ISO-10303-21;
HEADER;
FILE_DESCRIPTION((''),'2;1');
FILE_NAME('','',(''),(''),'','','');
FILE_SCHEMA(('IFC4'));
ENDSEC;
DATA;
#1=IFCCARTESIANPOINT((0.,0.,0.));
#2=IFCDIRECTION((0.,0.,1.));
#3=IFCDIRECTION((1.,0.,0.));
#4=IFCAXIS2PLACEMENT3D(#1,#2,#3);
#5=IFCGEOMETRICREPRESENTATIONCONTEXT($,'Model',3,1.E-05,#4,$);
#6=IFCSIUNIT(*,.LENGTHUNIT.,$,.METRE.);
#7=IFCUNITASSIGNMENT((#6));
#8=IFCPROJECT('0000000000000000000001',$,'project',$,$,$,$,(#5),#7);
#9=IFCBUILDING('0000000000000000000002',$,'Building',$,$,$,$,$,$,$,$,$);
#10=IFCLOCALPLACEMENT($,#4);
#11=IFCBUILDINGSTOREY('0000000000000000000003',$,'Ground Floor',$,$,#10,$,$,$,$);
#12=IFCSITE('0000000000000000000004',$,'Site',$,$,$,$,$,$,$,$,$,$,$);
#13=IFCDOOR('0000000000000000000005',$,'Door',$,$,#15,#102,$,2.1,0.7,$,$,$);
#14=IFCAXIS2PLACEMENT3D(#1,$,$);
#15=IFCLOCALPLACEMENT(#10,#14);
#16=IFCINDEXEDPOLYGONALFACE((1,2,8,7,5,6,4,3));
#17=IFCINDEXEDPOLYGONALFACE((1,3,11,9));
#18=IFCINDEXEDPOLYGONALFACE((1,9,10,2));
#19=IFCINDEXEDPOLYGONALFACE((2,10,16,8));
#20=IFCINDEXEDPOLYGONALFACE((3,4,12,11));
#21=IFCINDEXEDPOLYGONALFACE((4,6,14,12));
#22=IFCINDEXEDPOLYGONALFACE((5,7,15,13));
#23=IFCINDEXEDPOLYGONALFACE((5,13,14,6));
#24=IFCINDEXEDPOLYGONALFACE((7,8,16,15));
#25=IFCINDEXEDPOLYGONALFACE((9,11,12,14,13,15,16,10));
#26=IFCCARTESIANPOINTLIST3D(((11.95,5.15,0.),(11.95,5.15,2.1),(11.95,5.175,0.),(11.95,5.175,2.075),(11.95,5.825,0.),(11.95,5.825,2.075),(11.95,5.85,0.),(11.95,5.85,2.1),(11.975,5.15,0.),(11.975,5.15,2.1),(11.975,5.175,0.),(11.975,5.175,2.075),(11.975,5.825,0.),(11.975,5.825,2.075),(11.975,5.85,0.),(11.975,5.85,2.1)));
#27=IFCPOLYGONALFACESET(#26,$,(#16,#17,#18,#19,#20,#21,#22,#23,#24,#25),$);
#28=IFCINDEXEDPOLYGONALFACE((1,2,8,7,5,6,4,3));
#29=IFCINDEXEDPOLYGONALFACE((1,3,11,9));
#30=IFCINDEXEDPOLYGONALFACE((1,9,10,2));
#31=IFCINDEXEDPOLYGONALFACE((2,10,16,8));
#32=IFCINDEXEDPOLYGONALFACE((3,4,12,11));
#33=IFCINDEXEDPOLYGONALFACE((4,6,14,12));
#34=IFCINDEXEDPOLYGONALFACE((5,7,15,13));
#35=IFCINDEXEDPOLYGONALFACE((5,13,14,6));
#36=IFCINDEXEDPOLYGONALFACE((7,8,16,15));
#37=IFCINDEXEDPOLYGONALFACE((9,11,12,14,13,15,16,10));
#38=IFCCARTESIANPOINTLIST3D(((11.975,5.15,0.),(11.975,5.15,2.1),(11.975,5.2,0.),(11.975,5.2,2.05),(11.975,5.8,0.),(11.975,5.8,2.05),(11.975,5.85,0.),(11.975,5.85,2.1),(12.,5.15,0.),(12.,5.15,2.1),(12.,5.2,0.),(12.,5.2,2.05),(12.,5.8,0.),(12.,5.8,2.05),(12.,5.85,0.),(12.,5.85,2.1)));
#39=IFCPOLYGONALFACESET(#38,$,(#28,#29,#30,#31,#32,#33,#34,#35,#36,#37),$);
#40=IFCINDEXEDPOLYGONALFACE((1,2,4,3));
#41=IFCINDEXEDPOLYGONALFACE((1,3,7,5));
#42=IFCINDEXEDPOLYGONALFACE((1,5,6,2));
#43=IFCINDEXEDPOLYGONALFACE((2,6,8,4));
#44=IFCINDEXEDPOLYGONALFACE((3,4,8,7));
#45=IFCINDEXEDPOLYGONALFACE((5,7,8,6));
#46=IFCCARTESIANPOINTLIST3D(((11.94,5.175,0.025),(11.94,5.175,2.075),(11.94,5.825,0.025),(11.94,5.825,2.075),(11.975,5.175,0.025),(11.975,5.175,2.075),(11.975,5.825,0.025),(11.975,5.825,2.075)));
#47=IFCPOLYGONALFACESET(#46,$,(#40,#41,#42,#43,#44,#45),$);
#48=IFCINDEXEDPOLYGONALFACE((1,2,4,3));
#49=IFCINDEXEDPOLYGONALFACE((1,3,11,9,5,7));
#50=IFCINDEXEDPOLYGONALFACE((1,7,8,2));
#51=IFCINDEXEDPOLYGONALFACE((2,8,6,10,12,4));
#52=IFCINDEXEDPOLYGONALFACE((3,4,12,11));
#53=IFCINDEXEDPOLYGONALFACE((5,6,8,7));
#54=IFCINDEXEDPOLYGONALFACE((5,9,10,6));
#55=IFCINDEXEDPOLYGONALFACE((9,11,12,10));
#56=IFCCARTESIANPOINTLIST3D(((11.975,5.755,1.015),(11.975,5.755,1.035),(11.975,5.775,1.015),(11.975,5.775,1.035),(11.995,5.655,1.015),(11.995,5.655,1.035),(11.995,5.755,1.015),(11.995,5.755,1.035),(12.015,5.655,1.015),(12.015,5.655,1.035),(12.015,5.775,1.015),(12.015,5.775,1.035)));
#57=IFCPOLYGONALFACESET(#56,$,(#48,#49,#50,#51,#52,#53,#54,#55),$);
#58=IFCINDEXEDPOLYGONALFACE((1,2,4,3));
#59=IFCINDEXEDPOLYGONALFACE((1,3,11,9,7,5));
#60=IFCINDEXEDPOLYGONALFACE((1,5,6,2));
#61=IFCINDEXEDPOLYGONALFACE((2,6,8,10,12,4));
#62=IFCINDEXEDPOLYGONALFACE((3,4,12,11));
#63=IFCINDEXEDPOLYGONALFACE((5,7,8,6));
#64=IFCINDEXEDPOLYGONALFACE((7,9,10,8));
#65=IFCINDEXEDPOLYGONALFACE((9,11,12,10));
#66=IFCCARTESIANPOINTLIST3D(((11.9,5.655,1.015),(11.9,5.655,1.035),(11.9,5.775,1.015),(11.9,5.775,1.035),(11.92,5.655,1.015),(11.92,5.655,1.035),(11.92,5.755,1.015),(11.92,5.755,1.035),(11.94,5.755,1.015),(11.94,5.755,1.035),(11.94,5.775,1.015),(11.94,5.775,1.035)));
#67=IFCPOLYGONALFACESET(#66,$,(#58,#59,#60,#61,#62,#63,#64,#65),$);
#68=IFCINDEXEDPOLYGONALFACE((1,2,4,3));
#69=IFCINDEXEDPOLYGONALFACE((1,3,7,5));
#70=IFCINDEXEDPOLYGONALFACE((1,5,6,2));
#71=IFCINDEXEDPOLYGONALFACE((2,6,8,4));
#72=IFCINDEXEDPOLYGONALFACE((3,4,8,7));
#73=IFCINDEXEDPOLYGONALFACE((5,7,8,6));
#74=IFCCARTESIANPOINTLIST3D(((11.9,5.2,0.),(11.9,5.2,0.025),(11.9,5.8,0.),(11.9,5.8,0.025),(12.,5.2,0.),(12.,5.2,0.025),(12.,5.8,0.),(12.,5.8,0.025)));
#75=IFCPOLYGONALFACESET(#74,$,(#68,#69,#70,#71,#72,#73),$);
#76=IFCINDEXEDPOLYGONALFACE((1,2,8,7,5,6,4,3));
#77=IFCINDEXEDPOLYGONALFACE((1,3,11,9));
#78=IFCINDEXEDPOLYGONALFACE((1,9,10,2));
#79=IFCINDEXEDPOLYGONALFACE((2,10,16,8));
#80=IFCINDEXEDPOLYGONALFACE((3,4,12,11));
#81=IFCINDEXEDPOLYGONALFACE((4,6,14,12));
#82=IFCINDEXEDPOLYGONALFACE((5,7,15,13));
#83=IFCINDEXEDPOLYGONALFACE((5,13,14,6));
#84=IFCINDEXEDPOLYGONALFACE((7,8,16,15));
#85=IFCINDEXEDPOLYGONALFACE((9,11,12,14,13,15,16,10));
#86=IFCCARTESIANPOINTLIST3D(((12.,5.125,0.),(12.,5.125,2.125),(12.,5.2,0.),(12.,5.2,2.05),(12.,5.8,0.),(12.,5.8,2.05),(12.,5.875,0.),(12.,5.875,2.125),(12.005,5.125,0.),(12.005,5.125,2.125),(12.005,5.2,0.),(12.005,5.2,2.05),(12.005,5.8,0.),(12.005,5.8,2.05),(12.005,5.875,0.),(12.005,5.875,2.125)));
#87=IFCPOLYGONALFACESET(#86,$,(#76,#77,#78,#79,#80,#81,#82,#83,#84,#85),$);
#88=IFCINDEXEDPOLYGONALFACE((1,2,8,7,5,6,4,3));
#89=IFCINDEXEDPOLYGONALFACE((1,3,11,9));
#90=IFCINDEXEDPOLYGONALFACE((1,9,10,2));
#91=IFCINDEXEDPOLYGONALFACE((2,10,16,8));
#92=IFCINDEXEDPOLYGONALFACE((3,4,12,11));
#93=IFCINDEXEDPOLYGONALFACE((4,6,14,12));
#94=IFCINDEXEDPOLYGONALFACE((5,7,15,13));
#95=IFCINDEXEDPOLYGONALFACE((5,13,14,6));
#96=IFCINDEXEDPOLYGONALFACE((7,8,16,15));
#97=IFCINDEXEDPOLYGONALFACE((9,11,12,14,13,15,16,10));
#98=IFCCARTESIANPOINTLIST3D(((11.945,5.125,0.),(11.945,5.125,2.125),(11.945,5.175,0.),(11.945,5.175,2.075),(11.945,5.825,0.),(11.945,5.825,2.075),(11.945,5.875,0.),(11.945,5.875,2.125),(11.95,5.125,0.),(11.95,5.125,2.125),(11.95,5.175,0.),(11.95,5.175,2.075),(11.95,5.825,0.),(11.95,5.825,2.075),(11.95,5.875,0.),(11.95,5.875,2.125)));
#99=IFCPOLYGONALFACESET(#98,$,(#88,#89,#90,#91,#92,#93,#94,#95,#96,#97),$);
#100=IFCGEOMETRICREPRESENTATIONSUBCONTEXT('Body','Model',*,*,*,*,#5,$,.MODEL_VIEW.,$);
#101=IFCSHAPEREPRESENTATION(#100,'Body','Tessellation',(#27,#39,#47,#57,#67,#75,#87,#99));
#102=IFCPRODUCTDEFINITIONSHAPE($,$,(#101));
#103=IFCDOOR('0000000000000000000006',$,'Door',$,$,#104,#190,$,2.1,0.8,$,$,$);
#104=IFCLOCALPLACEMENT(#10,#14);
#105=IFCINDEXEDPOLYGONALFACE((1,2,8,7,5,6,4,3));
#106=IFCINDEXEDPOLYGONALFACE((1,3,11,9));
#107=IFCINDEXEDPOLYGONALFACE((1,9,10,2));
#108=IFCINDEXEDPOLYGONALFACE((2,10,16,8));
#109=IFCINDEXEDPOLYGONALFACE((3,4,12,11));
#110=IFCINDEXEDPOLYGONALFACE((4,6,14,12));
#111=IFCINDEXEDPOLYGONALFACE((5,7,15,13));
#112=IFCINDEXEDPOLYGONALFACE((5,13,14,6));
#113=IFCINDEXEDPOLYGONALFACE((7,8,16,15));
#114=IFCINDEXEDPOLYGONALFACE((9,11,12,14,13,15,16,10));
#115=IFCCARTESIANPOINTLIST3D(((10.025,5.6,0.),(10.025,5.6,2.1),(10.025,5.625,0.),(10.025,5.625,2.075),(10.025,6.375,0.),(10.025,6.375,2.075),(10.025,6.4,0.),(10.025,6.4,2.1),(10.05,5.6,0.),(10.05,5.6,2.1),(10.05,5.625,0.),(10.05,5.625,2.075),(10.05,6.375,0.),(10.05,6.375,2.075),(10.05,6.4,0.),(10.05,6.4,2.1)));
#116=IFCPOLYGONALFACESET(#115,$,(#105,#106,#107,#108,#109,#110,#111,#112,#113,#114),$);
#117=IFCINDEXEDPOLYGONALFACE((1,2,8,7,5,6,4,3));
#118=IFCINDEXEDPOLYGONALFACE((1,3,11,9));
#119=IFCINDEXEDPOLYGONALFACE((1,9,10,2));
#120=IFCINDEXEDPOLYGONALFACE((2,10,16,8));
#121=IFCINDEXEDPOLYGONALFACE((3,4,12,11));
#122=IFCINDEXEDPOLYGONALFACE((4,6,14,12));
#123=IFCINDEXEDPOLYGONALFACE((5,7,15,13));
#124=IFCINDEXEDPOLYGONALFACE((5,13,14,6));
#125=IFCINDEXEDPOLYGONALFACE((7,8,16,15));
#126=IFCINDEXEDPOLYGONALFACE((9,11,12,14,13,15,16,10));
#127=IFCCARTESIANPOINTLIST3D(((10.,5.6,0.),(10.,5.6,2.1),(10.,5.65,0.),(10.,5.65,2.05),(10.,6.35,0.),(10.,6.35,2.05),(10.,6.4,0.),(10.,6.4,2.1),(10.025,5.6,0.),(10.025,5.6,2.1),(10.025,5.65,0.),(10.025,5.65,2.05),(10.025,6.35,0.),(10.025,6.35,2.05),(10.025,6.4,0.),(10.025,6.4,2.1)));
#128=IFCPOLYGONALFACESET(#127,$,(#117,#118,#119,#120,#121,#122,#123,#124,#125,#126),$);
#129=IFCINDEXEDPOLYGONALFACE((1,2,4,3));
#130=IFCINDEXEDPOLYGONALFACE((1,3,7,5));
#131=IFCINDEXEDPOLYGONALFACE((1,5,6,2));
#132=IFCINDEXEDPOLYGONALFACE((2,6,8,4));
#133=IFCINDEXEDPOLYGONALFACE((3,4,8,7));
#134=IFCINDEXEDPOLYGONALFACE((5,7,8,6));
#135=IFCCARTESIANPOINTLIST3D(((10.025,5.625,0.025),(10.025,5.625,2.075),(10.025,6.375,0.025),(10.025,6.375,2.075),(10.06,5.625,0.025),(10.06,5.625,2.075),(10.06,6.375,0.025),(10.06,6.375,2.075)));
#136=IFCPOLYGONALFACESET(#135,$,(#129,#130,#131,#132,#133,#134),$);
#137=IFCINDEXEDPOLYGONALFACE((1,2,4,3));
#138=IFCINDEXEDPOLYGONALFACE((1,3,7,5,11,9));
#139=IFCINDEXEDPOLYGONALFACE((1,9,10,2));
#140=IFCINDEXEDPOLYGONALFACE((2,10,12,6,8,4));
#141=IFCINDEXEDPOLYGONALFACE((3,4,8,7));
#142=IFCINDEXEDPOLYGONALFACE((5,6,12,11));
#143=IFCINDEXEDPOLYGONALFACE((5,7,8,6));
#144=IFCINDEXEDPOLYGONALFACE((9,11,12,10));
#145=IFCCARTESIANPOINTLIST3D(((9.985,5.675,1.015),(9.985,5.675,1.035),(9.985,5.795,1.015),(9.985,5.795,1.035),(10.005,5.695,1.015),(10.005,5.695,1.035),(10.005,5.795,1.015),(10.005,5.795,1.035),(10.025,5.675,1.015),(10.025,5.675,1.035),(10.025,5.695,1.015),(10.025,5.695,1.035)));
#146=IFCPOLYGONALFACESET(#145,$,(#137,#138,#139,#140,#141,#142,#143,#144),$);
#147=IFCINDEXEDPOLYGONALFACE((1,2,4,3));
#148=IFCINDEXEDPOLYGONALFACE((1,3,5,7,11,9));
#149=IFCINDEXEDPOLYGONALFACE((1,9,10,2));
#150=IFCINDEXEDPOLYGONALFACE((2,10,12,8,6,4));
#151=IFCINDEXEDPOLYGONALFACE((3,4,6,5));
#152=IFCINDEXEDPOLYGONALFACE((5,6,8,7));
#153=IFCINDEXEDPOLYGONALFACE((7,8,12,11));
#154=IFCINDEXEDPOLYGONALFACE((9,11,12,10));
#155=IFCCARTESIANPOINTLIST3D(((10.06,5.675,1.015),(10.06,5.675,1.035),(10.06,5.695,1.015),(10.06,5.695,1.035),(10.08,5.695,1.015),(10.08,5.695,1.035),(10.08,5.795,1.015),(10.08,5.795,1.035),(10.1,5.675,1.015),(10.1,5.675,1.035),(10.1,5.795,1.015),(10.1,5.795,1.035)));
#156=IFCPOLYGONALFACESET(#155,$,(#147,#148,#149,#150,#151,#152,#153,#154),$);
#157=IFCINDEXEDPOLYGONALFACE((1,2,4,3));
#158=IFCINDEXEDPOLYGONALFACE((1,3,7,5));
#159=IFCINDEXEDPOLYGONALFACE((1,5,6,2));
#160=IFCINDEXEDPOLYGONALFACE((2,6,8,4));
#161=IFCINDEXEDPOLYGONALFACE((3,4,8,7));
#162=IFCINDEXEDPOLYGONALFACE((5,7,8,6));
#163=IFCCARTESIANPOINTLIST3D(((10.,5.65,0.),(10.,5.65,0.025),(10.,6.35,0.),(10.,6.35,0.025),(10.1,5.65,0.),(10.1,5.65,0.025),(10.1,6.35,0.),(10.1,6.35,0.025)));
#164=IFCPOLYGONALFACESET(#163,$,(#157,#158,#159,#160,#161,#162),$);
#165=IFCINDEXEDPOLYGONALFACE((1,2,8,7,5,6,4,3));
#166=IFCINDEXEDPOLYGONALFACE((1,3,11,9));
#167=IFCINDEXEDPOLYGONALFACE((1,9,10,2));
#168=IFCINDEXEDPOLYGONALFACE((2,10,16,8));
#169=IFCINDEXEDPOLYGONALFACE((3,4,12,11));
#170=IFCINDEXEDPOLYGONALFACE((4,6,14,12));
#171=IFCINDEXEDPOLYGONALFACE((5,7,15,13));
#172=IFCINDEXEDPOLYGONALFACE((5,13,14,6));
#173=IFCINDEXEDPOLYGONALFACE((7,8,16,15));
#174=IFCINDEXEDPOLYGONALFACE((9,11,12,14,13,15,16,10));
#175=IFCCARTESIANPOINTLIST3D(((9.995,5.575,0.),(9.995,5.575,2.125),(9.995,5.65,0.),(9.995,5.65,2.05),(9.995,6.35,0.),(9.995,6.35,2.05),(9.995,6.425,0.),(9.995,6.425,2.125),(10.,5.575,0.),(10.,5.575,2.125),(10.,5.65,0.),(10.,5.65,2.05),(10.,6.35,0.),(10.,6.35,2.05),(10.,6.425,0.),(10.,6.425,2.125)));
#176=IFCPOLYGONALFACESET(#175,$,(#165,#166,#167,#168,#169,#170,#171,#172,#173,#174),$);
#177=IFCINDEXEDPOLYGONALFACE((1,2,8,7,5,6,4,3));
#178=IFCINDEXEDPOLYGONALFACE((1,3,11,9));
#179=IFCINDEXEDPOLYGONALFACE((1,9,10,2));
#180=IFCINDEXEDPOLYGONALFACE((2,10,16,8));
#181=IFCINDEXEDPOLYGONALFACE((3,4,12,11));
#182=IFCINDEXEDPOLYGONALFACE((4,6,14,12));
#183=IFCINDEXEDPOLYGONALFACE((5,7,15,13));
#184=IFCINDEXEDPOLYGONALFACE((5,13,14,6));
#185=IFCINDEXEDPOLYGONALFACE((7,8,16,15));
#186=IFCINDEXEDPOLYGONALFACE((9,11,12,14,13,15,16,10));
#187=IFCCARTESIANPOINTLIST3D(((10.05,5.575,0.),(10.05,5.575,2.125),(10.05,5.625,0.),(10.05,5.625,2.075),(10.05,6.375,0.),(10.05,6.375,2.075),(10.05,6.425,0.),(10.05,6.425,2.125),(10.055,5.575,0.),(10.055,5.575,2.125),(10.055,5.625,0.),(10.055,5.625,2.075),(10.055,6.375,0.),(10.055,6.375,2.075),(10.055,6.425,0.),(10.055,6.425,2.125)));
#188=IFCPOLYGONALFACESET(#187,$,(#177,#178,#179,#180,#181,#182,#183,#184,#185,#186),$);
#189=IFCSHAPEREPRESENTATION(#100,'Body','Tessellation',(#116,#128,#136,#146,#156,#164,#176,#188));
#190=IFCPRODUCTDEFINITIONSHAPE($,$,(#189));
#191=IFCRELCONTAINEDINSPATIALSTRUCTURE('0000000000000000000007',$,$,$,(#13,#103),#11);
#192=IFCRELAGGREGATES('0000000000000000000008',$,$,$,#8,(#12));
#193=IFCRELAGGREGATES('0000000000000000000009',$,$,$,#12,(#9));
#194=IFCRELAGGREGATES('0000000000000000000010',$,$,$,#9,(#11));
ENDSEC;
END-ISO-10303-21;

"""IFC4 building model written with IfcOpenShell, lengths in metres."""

from ifc_helpers import new_model, si_unit, frame, origin_with_axes, place, context, subcontext, project, spatial, line, indexed_curve, outline, extrude, element, save


model = new_model("IFC4")

# Units and contexts
model_context = context("Model", 3, precision=1e-05, world=origin_with_axes())
body_context = subcontext(model_context, "Body", "Model", "MODEL_VIEW")
ifc_project = project(units=[si_unit("LENGTHUNIT", "METRE")], contexts=[model_context])

# Site, building, storey
site = spatial("IfcSite", under=ifc_project, Name="Site")
building = spatial("IfcBuilding", under=site, Name="Building")
storey_placement = place(None, origin_with_axes())
storey = spatial("IfcBuildingStorey", under=building, at=storey_placement, Name="Ground Floor")

# Doors
door_1_placement = place(storey_placement, frame((12.0, 5.15, 0.0), z_axis=(0.0, 0.0, 1.0), x_axis=(0.0, 1.0, 0.0)))
element("IfcDoor", 1, at=door_1_placement, inside=storey, Name="Door", OverallHeight=2.1, OverallWidth=0.7, context=body_context, shape_type="SweptSolid", body=[
    extrude(outline(indexed_curve([(0.0, 0.0), (0.0, 2.1), (0.7, 2.1), (0.7, 0.0), (0.675, 0.0), (0.675, 2.075), (0.025, 2.075), (0.025, 0.0)], segments=[line(1, 2, 3, 4, 5, 6, 7, 8, 1)])), frame((0.0, 0.025, 0.0), z_axis=(0.0, -1.0, 0.0), x_axis=(1.0, 0.0, 0.0)), (0.0, 0.0, -1.0), 0.025),
    extrude(outline(indexed_curve([(0.0, 0.0), (0.0, 2.1), (0.7, 2.1), (0.7, 0.0), (0.65, 0.0), (0.65, 2.05), (0.05, 2.05), (0.05, 0.0)], segments=[line(1, 2, 3, 4, 5, 6, 7, 8, 1)])), frame((0.0, 0.0, 0.0), z_axis=(0.0, -1.0, 0.0), x_axis=(1.0, 0.0, 0.0)), (0.0, 0.0, -1.0), 0.025),
    extrude(outline(indexed_curve([(0.0, 0.0), (0.65, 0.0), (0.65, 0.035), (0.0, 0.035)], segments=[line(1, 2, 3, 4, 1)])), frame((0.025, 0.025, 0.025), z_axis=(0.0, 0.0, 1.0), x_axis=(1.0, 0.0, 0.0)), (0.0, 0.0, 1.0), 2.05),
    extrude(outline(indexed_curve([(0.0, 0.0), (0.0, -0.04), (-0.12, -0.04), (-0.12, -0.02), (-0.02, -0.02), (-0.02, 0.0)], segments=[line(1, 2, 3, 4, 5, 6, 1)])), frame((0.625, 0.025, 1.015), z_axis=(0.0, 0.0, 1.0), x_axis=(1.0, 0.0, 0.0)), (0.0, 0.0, 1.0), 0.02),
    extrude(outline(indexed_curve([(0.0, 0.0), (0.0, 0.04), (-0.12, 0.04), (-0.12, 0.02), (-0.02, 0.02), (-0.02, 0.0)], segments=[line(1, 2, 3, 4, 5, 6, 1)])), frame((0.625, 0.06, 1.015), z_axis=(0.0, 0.0, 1.0), x_axis=(1.0, 0.0, 0.0)), (0.0, 0.0, 1.0), 0.02),
    extrude(outline(indexed_curve([(0.0, 0.0), (0.6, 0.0), (0.6, 0.1), (0.0, 0.1)], segments=[line(1, 2, 3, 4, 1)])), frame((0.05, 0.0, 0.0), z_axis=(0.0, 0.0, 1.0), x_axis=(1.0, 0.0, 0.0)), (0.0, 0.0, 1.0), 0.025),
    extrude(outline(indexed_curve([(0.0, 0.0), (0.0, 2.125), (0.75, 2.125), (0.75, 0.0), (0.675, 0.0), (0.675, 2.05), (0.075, 2.05), (0.075, 0.0)], segments=[line(1, 2, 3, 4, 5, 6, 7, 8, 1)])), frame((-0.025, -0.005, 0.0), z_axis=(0.0, -1.0, 0.0), x_axis=(1.0, 0.0, 0.0)), (0.0, 0.0, -1.0), 0.005),
    extrude(outline(indexed_curve([(0.0, 0.0), (0.0, 2.125), (0.75, 2.125), (0.75, 0.0), (0.7, 0.0), (0.7, 2.075), (0.05, 2.075), (0.05, 0.0)], segments=[line(1, 2, 3, 4, 5, 6, 7, 8, 1)])), frame((-0.025, 0.05, 0.0), z_axis=(0.0, -1.0, 0.0), x_axis=(1.0, 0.0, 0.0)), (0.0, 0.0, -1.0), 0.005),
])
door_2_placement = place(storey_placement, frame((10.0, 6.4, 0.0), z_axis=(0.0, 0.0, 1.0), x_axis=(0.0, -1.0, 0.0)))
element("IfcDoor", 2, at=door_2_placement, inside=storey, Name="Door", OverallHeight=2.1, OverallWidth=0.8, context=body_context, shape_type="SweptSolid", body=[
    extrude(outline(indexed_curve([(0.0, 0.0), (0.0, 2.1), (0.8, 2.1), (0.8, 0.0), (0.775, 0.0), (0.775, 2.075), (0.025, 2.075), (0.025, 0.0)], segments=[line(1, 2, 3, 4, 5, 6, 7, 8, 1)])), frame((0.0, 0.025, 0.0), z_axis=(0.0, -1.0, 0.0), x_axis=(1.0, 0.0, 0.0)), (0.0, 0.0, -1.0), 0.025),
    extrude(outline(indexed_curve([(0.0, 0.0), (0.0, 2.1), (0.8, 2.1), (0.8, 0.0), (0.75, 0.0), (0.75, 2.05), (0.05, 2.05), (0.05, 0.0)], segments=[line(1, 2, 3, 4, 5, 6, 7, 8, 1)])), frame((0.0, 0.0, 0.0), z_axis=(0.0, -1.0, 0.0), x_axis=(1.0, 0.0, 0.0)), (0.0, 0.0, -1.0), 0.025),
    extrude(outline(indexed_curve([(0.0, 0.0), (0.75, 0.0), (0.75, 0.035), (0.0, 0.035)], segments=[line(1, 2, 3, 4, 1)])), frame((0.025, 0.025, 0.025), z_axis=(0.0, 0.0, 1.0), x_axis=(1.0, 0.0, 0.0)), (0.0, 0.0, 1.0), 2.05),
    extrude(outline(indexed_curve([(0.0, 0.0), (0.0, -0.04), (-0.12, -0.04), (-0.12, -0.02), (-0.02, -0.02), (-0.02, 0.0)], segments=[line(1, 2, 3, 4, 5, 6, 1)])), frame((0.725, 0.025, 1.015), z_axis=(0.0, 0.0, 1.0), x_axis=(1.0, 0.0, 0.0)), (0.0, 0.0, 1.0), 0.02),
    extrude(outline(indexed_curve([(0.0, 0.0), (0.0, 0.04), (-0.12, 0.04), (-0.12, 0.02), (-0.02, 0.02), (-0.02, 0.0)], segments=[line(1, 2, 3, 4, 5, 6, 1)])), frame((0.725, 0.06, 1.015), z_axis=(0.0, 0.0, 1.0), x_axis=(1.0, 0.0, 0.0)), (0.0, 0.0, 1.0), 0.02),
    extrude(outline(indexed_curve([(0.0, 0.0), (0.7, 0.0), (0.7, 0.1), (0.0, 0.1)], segments=[line(1, 2, 3, 4, 1)])), frame((0.05, 0.0, 0.0), z_axis=(0.0, 0.0, 1.0), x_axis=(1.0, 0.0, 0.0)), (0.0, 0.0, 1.0), 0.025),
    extrude(outline(indexed_curve([(0.0, 0.0), (0.0, 2.125), (0.85, 2.125), (0.85, 0.0), (0.775, 0.0), (0.775, 2.05), (0.075, 2.05), (0.075, 0.0)], segments=[line(1, 2, 3, 4, 5, 6, 7, 8, 1)])), frame((-0.025, -0.005, 0.0), z_axis=(0.0, -1.0, 0.0), x_axis=(1.0, 0.0, 0.0)), (0.0, 0.0, -1.0), 0.005),
    extrude(outline(indexed_curve([(0.0, 0.0), (0.0, 2.125), (0.85, 2.125), (0.85, 0.0), (0.8, 0.0), (0.8, 2.075), (0.05, 2.075), (0.05, 0.0)], segments=[line(1, 2, 3, 4, 5, 6, 7, 8, 1)])), frame((-0.025, 0.05, 0.0), z_axis=(0.0, -1.0, 0.0), x_axis=(1.0, 0.0, 0.0)), (0.0, 0.0, -1.0), 0.005),
])

save(model, "model.ifc")
